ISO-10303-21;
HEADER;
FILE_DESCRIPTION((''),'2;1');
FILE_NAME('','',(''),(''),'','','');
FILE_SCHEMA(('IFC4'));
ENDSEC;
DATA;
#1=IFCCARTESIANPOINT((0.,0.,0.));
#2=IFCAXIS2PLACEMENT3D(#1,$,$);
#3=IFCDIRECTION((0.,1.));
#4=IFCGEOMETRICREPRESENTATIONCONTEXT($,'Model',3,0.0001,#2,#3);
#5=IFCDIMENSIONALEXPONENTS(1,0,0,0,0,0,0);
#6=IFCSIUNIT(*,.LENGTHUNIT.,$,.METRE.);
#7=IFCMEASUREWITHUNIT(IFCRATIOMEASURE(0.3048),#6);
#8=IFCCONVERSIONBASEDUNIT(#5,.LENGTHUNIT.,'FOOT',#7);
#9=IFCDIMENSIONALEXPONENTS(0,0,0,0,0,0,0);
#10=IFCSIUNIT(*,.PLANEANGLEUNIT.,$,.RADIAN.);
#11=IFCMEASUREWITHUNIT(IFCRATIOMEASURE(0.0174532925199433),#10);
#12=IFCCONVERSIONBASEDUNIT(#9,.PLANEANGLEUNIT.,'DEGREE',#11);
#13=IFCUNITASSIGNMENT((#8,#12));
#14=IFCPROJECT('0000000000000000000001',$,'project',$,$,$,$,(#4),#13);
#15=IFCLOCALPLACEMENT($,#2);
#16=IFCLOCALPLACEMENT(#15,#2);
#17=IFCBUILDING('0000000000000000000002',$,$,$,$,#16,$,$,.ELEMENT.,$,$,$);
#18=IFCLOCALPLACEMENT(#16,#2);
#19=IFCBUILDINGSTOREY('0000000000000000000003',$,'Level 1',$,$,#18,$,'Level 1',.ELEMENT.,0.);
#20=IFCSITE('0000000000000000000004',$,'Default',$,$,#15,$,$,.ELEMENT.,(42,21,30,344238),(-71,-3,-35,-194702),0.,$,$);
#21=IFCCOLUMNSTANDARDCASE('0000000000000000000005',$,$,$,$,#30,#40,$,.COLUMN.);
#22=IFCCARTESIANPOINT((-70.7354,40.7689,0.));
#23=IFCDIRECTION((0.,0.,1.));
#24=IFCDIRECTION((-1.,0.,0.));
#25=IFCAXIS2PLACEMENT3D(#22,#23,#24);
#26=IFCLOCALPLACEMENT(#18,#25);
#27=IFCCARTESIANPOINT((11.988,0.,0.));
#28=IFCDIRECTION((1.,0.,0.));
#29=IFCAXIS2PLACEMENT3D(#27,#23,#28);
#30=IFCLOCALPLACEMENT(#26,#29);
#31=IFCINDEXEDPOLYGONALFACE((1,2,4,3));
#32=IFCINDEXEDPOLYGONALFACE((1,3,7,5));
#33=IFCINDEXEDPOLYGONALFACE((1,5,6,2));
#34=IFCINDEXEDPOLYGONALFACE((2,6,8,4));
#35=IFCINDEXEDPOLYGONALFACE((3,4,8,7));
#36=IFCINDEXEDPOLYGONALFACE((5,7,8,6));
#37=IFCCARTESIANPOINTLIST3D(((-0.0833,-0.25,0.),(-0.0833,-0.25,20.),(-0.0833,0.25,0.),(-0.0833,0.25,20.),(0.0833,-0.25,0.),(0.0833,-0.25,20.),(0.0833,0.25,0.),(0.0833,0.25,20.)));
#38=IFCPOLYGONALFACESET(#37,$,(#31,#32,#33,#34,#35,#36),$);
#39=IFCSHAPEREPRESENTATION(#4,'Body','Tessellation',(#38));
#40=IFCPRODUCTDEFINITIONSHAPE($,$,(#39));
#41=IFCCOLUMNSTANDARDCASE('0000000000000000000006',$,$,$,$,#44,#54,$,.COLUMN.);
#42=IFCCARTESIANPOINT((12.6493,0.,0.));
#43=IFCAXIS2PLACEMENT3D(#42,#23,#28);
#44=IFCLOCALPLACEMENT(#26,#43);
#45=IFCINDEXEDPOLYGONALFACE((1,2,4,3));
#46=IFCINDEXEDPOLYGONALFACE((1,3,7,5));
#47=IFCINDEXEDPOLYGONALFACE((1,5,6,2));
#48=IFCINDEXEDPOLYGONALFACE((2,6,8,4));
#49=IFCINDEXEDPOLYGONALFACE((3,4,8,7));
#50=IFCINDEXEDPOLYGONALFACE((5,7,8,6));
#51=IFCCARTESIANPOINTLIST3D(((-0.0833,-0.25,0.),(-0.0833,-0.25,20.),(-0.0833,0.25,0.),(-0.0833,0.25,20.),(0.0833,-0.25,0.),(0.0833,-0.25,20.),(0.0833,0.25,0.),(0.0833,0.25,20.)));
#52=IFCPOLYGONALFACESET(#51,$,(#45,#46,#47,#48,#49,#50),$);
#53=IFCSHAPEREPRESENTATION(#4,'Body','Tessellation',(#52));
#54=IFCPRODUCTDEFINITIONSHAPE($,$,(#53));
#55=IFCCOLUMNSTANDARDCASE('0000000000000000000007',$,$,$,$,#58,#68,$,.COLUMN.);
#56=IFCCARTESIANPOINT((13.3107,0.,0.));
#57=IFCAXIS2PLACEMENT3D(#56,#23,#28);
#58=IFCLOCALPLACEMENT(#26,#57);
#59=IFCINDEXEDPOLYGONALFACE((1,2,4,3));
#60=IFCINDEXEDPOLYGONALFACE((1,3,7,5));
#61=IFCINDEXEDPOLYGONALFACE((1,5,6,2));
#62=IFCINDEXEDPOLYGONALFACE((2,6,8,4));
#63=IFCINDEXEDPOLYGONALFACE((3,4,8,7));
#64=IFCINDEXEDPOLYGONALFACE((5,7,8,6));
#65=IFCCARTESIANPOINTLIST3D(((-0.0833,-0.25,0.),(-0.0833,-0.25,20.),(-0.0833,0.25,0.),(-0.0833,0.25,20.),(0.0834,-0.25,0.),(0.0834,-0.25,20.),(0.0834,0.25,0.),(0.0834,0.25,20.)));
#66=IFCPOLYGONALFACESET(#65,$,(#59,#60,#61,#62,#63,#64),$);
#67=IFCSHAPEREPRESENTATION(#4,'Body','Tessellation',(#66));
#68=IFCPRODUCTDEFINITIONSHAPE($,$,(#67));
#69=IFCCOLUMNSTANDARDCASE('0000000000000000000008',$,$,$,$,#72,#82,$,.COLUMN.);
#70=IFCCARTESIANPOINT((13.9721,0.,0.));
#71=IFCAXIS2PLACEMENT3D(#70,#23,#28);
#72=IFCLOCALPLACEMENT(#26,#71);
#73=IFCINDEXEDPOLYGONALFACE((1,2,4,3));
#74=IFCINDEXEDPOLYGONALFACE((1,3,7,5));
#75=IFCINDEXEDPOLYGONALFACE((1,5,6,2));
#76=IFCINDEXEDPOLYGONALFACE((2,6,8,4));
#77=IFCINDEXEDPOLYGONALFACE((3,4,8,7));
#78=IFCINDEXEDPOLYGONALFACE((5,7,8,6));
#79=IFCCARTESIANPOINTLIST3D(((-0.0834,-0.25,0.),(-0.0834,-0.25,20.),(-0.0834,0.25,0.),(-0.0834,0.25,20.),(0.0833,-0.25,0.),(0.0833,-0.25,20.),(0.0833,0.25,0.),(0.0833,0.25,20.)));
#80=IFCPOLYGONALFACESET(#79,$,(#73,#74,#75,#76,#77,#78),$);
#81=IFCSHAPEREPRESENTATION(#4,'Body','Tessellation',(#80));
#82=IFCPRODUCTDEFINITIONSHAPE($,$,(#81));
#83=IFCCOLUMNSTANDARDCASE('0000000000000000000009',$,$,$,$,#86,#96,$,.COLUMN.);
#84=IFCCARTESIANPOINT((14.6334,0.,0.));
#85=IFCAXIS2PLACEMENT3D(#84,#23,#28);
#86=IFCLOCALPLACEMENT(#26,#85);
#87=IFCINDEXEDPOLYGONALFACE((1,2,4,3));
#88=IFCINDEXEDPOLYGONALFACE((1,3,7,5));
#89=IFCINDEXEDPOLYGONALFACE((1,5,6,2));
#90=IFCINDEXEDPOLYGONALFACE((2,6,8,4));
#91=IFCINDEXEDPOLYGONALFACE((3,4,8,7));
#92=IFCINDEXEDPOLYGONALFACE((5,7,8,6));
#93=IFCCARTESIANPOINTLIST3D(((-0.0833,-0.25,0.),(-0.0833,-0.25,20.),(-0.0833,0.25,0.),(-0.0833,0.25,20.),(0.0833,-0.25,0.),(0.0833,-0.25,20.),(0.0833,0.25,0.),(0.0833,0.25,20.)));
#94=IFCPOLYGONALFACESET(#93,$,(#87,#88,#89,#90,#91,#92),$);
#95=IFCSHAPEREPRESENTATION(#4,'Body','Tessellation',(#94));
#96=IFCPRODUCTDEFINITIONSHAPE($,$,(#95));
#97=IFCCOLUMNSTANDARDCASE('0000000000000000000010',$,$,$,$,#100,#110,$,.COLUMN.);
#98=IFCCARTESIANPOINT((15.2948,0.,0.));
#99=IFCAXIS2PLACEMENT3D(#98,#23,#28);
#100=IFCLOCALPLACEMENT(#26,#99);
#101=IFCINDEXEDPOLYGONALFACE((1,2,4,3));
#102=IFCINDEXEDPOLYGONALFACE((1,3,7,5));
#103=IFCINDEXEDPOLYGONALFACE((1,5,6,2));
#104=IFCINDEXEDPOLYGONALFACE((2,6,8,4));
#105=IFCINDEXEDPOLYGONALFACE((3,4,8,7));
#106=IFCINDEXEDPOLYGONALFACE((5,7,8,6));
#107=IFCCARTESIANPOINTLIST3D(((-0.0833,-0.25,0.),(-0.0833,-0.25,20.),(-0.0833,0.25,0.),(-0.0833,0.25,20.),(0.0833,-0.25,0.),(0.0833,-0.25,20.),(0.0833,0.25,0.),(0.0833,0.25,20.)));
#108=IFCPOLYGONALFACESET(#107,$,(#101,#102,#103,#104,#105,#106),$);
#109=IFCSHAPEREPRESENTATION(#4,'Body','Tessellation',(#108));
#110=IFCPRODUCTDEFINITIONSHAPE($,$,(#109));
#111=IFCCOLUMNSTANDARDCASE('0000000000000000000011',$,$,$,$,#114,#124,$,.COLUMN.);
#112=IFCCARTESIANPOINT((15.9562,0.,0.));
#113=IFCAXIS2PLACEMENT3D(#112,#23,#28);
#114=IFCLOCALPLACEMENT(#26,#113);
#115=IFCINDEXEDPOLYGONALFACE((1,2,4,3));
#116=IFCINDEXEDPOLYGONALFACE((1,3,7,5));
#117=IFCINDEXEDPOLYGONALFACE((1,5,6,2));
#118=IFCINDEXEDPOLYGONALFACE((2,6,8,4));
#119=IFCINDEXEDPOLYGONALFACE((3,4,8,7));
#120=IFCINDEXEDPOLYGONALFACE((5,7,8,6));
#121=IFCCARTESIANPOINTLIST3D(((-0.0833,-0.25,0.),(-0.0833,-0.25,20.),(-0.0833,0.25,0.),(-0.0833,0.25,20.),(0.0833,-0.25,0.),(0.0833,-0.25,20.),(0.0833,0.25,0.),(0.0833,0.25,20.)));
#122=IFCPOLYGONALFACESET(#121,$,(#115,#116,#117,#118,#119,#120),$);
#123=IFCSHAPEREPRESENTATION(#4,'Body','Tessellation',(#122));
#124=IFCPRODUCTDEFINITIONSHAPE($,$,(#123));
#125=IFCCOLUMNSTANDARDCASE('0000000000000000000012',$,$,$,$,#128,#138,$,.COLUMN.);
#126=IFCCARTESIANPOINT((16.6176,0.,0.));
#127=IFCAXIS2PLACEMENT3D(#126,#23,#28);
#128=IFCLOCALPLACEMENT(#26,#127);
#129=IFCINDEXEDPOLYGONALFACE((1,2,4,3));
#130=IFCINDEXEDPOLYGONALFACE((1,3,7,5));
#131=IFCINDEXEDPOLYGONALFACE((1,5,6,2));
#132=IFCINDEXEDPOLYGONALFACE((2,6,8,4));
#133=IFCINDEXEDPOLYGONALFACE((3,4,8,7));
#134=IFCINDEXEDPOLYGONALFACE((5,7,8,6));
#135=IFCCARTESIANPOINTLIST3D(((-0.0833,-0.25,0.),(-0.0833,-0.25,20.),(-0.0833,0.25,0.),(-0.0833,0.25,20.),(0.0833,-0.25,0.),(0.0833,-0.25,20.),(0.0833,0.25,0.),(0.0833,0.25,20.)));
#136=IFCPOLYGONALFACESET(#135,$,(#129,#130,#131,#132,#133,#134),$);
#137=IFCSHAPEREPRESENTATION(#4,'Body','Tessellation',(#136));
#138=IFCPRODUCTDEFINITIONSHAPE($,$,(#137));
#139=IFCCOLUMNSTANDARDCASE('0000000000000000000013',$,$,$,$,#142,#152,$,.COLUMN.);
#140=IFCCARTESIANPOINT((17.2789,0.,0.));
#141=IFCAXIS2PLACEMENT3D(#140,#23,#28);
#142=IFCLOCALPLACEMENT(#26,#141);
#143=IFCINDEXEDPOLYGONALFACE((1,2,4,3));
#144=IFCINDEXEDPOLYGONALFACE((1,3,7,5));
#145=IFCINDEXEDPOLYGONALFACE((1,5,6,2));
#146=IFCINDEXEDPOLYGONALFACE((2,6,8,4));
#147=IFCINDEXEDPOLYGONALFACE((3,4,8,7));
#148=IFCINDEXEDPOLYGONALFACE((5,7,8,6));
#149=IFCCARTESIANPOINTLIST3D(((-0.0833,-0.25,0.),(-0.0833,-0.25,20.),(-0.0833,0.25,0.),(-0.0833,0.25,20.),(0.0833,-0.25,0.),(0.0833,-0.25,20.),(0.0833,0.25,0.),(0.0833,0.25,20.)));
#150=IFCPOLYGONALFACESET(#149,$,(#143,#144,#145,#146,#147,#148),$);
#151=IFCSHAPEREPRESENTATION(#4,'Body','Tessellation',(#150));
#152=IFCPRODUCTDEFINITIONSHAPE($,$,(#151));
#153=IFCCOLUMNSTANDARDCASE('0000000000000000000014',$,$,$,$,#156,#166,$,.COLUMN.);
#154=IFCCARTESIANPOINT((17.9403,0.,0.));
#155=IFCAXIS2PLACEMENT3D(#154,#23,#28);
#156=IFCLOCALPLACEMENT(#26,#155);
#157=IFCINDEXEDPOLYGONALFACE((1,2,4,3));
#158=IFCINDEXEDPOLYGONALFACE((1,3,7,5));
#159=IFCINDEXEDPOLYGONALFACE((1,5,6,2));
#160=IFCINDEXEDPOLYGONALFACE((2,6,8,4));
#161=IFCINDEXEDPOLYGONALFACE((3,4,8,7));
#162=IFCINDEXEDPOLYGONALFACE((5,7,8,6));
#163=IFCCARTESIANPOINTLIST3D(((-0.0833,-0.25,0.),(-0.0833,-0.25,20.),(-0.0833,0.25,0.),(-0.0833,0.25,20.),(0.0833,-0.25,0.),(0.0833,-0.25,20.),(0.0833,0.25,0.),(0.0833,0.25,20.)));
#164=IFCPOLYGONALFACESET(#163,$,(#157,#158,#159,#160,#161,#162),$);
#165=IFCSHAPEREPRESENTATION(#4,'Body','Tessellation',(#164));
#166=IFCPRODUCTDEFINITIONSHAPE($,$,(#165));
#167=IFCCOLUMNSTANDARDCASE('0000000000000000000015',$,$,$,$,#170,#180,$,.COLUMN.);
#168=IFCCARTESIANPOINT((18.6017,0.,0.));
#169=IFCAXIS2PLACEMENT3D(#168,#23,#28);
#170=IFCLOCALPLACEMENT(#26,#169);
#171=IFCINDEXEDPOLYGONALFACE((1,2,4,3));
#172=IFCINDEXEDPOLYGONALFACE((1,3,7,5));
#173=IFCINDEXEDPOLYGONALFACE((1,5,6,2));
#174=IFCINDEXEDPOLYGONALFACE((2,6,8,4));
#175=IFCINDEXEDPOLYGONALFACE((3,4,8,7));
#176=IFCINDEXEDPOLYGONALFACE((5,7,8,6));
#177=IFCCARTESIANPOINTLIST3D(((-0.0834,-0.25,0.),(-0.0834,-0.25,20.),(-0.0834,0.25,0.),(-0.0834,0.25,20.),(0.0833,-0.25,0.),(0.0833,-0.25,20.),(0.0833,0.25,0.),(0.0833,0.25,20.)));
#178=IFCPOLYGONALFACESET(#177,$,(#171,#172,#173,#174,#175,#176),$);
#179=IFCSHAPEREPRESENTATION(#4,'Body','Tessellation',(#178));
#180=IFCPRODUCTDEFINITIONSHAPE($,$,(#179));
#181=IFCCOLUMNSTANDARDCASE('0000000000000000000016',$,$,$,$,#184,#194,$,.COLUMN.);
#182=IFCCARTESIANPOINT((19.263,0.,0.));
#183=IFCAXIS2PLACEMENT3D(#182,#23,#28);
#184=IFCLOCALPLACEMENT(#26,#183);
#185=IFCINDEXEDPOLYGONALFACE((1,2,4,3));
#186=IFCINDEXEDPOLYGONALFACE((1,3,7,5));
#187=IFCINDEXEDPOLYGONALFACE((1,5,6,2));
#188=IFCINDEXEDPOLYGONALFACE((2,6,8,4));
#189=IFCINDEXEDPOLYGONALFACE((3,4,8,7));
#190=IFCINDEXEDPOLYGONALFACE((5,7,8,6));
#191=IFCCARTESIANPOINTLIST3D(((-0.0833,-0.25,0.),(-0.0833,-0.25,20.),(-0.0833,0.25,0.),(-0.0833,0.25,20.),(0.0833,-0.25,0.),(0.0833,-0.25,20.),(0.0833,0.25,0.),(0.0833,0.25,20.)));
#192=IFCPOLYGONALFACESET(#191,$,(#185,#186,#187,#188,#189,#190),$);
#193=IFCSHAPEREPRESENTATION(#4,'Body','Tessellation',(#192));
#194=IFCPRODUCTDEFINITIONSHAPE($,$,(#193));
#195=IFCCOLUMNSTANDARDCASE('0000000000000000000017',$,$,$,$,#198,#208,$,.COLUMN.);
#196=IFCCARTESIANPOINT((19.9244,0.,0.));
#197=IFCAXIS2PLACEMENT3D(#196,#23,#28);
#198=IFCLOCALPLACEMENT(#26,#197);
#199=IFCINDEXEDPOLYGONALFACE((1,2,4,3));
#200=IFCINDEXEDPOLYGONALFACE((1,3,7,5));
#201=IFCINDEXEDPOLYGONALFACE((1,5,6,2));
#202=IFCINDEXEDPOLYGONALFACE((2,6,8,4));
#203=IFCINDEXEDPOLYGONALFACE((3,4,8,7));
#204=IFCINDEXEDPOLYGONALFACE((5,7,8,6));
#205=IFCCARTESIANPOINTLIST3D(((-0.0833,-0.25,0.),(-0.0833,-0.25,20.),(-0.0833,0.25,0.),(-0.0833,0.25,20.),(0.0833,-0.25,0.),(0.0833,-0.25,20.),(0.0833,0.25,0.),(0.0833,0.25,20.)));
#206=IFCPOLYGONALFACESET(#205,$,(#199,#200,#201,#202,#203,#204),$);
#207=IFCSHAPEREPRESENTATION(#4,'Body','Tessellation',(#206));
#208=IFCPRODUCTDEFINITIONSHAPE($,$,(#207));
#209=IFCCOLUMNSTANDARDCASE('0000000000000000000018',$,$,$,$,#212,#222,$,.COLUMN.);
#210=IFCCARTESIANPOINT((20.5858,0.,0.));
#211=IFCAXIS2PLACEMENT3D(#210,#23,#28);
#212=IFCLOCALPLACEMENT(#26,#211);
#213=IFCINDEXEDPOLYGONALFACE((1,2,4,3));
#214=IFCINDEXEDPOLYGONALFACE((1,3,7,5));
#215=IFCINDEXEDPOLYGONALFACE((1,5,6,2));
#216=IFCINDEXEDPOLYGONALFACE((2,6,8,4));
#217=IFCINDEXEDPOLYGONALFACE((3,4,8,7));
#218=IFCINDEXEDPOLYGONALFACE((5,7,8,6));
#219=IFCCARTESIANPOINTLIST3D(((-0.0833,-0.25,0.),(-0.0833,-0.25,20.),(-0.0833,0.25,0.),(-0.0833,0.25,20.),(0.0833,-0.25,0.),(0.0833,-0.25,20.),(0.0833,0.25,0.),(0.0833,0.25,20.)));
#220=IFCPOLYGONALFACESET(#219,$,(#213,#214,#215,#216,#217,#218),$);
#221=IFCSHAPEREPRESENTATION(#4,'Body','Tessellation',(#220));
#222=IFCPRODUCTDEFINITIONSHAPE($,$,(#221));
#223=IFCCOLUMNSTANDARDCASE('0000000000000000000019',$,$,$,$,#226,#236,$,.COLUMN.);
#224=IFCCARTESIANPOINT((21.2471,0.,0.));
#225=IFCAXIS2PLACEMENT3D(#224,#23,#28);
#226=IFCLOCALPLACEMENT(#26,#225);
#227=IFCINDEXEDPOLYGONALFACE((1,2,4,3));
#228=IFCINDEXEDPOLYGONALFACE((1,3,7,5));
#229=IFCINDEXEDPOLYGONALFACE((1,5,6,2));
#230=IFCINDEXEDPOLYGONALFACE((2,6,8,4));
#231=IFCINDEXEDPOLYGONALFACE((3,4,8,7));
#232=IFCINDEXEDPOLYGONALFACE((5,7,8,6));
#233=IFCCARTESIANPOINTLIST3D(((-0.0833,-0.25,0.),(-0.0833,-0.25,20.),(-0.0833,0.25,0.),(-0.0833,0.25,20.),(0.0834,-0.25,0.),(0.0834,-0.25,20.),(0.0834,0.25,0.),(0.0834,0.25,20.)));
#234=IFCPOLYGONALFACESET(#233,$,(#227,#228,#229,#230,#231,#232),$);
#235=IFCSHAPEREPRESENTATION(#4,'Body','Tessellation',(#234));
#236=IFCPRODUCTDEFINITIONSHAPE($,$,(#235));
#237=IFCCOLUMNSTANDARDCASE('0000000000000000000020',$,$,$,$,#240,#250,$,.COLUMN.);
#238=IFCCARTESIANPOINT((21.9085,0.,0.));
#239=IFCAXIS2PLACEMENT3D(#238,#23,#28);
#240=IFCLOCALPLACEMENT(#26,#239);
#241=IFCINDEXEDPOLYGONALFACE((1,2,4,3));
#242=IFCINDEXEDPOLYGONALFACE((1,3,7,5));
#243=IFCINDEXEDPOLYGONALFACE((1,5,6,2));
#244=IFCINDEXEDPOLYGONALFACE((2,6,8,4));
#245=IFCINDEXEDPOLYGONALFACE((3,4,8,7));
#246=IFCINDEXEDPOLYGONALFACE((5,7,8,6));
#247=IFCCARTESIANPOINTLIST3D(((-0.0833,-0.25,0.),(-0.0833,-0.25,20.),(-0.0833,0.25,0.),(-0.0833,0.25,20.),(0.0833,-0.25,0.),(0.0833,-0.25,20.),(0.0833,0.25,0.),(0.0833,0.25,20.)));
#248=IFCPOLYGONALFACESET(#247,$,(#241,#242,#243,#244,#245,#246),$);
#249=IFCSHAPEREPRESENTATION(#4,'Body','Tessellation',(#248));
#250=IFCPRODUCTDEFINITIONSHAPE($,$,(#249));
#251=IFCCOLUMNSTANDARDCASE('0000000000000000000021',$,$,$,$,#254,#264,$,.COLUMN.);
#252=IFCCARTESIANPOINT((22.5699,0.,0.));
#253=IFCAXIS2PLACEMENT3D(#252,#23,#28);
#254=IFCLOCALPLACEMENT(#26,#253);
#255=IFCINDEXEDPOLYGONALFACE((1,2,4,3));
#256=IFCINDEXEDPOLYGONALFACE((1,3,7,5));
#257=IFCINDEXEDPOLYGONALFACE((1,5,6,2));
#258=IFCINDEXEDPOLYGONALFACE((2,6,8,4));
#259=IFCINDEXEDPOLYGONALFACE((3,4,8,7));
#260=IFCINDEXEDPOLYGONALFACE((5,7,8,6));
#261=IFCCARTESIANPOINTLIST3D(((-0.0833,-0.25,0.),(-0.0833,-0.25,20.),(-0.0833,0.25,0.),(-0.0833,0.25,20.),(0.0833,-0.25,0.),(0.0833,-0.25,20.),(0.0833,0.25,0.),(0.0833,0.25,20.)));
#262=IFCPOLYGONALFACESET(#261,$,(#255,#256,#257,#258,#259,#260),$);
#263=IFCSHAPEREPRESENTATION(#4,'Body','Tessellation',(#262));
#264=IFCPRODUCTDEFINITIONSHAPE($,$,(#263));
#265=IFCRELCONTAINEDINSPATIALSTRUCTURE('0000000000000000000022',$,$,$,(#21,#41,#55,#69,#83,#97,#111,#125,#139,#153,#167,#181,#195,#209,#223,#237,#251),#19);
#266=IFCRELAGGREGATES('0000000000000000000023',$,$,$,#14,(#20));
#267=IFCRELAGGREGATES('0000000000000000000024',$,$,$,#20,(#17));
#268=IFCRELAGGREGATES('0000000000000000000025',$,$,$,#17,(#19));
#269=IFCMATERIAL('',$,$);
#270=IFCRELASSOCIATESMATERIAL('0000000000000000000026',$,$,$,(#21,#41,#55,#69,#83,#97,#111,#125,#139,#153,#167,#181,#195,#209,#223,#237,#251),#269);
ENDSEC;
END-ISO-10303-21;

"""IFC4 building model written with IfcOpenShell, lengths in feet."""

from ifc_helpers import new_model, entity, si_unit, converted_unit, direction, frame, origin, place, context, project, spatial, rectangle, extrude, material, element, save


model = new_model("IFC4")

# Units and contexts
model_context = context("Model", 3, precision=0.0001, world=origin(), true_north=direction((0.0, 1.0)))
ifc_project = project(units=[converted_unit("LENGTHUNIT", "FOOT", entity("IfcRatioMeasure", 0.3048), si_unit("LENGTHUNIT", "METRE"), dimensions=[1, 0, 0, 0, 0, 0, 0]), converted_unit("PLANEANGLEUNIT", "DEGREE", entity("IfcRatioMeasure", 0.0174532925199433), si_unit("PLANEANGLEUNIT", "RADIAN"), dimensions=[0, 0, 0, 0, 0, 0, 0])], contexts=[model_context])

# Site, building, storey
site_placement = place(None, origin())
site = spatial("IfcSite", under=ifc_project, at=site_placement, Name="Default", CompositionType="ELEMENT", RefLatitude=(42, 21, 30, 344238), RefLongitude=(-71, -3, -35, -194702), RefElevation=0.0)
building_placement = place(site_placement, origin())
building = spatial("IfcBuilding", under=site, at=building_placement, CompositionType="ELEMENT")
storey_placement = place(building_placement, origin())
storey = spatial("IfcBuildingStorey", under=building, at=storey_placement, Name="Level 1", LongName="Level 1", CompositionType="ELEMENT", Elevation=0.0)

# Columns
ifc_material_1 = material(Name="")
placement_1 = place(storey_placement, frame((-70.7354, 40.7689, 0.0), z_axis=(0.0, 0.0, 1.0), x_axis=(-1.0, 0.0, 0.0)))
for number, where, z_axis, x_axis in (
    (1, (11.988, 0.0, 0.0), (0.0, 0.0, 1.0), (1.0, 0.0, 0.0)),
    (2, (12.6493, 0.0, 0.0), (0.0, 0.0, 1.0), (1.0, 0.0, 0.0)),
    (3, (13.3107, 0.0, 0.0), (0.0, 0.0, 1.0), (1.0, 0.0, 0.0)),
    (4, (13.9721, 0.0, 0.0), (0.0, 0.0, 1.0), (1.0, 0.0, 0.0)),
    (5, (14.6334, 0.0, 0.0), (0.0, 0.0, 1.0), (1.0, 0.0, 0.0)),
    (6, (15.2948, 0.0, 0.0), (0.0, 0.0, 1.0), (1.0, 0.0, 0.0)),
    (7, (15.9562, 0.0, 0.0), (0.0, 0.0, 1.0), (1.0, 0.0, 0.0)),
    (8, (16.6176, 0.0, 0.0), (0.0, 0.0, 1.0), (1.0, 0.0, 0.0)),
    (9, (17.2789, 0.0, 0.0), (0.0, 0.0, 1.0), (1.0, 0.0, 0.0)),
    (10, (17.9403, 0.0, 0.0), (0.0, 0.0, 1.0), (1.0, 0.0, 0.0)),
    (11, (18.6017, 0.0, 0.0), (0.0, 0.0, 1.0), (1.0, 0.0, 0.0)),
    (12, (19.263, 0.0, 0.0), (0.0, 0.0, 1.0), (1.0, 0.0, 0.0)),
    (13, (19.9244, 0.0, 0.0), (0.0, 0.0, 1.0), (1.0, 0.0, 0.0)),
    (14, (20.5858, 0.0, 0.0), (0.0, 0.0, 1.0), (1.0, 0.0, 0.0)),
    (15, (21.2471, 0.0, 0.0), (0.0, 0.0, 1.0), (1.0, 0.0, 0.0)),
    (16, (21.9085, 0.0, 0.0), (0.0, 0.0, 1.0), (1.0, 0.0, 0.0)),
    (17, (22.5699, 0.0, 0.0), (0.0, 0.0, 1.0), (1.0, 0.0, 0.0)),
):
    element("IfcColumnStandardCase", number, at=place(placement_1, frame(where, z_axis=z_axis, x_axis=x_axis)), inside=storey, material=ifc_material_1, PredefinedType="COLUMN", context=model_context, shape_type="SweptSolid", body=[
        extrude(rectangle(XDim=0.1667, YDim=0.5), origin(), (0.0, 0.0, 1.0), 20.0),
    ])

save(model, "model.ifc")
